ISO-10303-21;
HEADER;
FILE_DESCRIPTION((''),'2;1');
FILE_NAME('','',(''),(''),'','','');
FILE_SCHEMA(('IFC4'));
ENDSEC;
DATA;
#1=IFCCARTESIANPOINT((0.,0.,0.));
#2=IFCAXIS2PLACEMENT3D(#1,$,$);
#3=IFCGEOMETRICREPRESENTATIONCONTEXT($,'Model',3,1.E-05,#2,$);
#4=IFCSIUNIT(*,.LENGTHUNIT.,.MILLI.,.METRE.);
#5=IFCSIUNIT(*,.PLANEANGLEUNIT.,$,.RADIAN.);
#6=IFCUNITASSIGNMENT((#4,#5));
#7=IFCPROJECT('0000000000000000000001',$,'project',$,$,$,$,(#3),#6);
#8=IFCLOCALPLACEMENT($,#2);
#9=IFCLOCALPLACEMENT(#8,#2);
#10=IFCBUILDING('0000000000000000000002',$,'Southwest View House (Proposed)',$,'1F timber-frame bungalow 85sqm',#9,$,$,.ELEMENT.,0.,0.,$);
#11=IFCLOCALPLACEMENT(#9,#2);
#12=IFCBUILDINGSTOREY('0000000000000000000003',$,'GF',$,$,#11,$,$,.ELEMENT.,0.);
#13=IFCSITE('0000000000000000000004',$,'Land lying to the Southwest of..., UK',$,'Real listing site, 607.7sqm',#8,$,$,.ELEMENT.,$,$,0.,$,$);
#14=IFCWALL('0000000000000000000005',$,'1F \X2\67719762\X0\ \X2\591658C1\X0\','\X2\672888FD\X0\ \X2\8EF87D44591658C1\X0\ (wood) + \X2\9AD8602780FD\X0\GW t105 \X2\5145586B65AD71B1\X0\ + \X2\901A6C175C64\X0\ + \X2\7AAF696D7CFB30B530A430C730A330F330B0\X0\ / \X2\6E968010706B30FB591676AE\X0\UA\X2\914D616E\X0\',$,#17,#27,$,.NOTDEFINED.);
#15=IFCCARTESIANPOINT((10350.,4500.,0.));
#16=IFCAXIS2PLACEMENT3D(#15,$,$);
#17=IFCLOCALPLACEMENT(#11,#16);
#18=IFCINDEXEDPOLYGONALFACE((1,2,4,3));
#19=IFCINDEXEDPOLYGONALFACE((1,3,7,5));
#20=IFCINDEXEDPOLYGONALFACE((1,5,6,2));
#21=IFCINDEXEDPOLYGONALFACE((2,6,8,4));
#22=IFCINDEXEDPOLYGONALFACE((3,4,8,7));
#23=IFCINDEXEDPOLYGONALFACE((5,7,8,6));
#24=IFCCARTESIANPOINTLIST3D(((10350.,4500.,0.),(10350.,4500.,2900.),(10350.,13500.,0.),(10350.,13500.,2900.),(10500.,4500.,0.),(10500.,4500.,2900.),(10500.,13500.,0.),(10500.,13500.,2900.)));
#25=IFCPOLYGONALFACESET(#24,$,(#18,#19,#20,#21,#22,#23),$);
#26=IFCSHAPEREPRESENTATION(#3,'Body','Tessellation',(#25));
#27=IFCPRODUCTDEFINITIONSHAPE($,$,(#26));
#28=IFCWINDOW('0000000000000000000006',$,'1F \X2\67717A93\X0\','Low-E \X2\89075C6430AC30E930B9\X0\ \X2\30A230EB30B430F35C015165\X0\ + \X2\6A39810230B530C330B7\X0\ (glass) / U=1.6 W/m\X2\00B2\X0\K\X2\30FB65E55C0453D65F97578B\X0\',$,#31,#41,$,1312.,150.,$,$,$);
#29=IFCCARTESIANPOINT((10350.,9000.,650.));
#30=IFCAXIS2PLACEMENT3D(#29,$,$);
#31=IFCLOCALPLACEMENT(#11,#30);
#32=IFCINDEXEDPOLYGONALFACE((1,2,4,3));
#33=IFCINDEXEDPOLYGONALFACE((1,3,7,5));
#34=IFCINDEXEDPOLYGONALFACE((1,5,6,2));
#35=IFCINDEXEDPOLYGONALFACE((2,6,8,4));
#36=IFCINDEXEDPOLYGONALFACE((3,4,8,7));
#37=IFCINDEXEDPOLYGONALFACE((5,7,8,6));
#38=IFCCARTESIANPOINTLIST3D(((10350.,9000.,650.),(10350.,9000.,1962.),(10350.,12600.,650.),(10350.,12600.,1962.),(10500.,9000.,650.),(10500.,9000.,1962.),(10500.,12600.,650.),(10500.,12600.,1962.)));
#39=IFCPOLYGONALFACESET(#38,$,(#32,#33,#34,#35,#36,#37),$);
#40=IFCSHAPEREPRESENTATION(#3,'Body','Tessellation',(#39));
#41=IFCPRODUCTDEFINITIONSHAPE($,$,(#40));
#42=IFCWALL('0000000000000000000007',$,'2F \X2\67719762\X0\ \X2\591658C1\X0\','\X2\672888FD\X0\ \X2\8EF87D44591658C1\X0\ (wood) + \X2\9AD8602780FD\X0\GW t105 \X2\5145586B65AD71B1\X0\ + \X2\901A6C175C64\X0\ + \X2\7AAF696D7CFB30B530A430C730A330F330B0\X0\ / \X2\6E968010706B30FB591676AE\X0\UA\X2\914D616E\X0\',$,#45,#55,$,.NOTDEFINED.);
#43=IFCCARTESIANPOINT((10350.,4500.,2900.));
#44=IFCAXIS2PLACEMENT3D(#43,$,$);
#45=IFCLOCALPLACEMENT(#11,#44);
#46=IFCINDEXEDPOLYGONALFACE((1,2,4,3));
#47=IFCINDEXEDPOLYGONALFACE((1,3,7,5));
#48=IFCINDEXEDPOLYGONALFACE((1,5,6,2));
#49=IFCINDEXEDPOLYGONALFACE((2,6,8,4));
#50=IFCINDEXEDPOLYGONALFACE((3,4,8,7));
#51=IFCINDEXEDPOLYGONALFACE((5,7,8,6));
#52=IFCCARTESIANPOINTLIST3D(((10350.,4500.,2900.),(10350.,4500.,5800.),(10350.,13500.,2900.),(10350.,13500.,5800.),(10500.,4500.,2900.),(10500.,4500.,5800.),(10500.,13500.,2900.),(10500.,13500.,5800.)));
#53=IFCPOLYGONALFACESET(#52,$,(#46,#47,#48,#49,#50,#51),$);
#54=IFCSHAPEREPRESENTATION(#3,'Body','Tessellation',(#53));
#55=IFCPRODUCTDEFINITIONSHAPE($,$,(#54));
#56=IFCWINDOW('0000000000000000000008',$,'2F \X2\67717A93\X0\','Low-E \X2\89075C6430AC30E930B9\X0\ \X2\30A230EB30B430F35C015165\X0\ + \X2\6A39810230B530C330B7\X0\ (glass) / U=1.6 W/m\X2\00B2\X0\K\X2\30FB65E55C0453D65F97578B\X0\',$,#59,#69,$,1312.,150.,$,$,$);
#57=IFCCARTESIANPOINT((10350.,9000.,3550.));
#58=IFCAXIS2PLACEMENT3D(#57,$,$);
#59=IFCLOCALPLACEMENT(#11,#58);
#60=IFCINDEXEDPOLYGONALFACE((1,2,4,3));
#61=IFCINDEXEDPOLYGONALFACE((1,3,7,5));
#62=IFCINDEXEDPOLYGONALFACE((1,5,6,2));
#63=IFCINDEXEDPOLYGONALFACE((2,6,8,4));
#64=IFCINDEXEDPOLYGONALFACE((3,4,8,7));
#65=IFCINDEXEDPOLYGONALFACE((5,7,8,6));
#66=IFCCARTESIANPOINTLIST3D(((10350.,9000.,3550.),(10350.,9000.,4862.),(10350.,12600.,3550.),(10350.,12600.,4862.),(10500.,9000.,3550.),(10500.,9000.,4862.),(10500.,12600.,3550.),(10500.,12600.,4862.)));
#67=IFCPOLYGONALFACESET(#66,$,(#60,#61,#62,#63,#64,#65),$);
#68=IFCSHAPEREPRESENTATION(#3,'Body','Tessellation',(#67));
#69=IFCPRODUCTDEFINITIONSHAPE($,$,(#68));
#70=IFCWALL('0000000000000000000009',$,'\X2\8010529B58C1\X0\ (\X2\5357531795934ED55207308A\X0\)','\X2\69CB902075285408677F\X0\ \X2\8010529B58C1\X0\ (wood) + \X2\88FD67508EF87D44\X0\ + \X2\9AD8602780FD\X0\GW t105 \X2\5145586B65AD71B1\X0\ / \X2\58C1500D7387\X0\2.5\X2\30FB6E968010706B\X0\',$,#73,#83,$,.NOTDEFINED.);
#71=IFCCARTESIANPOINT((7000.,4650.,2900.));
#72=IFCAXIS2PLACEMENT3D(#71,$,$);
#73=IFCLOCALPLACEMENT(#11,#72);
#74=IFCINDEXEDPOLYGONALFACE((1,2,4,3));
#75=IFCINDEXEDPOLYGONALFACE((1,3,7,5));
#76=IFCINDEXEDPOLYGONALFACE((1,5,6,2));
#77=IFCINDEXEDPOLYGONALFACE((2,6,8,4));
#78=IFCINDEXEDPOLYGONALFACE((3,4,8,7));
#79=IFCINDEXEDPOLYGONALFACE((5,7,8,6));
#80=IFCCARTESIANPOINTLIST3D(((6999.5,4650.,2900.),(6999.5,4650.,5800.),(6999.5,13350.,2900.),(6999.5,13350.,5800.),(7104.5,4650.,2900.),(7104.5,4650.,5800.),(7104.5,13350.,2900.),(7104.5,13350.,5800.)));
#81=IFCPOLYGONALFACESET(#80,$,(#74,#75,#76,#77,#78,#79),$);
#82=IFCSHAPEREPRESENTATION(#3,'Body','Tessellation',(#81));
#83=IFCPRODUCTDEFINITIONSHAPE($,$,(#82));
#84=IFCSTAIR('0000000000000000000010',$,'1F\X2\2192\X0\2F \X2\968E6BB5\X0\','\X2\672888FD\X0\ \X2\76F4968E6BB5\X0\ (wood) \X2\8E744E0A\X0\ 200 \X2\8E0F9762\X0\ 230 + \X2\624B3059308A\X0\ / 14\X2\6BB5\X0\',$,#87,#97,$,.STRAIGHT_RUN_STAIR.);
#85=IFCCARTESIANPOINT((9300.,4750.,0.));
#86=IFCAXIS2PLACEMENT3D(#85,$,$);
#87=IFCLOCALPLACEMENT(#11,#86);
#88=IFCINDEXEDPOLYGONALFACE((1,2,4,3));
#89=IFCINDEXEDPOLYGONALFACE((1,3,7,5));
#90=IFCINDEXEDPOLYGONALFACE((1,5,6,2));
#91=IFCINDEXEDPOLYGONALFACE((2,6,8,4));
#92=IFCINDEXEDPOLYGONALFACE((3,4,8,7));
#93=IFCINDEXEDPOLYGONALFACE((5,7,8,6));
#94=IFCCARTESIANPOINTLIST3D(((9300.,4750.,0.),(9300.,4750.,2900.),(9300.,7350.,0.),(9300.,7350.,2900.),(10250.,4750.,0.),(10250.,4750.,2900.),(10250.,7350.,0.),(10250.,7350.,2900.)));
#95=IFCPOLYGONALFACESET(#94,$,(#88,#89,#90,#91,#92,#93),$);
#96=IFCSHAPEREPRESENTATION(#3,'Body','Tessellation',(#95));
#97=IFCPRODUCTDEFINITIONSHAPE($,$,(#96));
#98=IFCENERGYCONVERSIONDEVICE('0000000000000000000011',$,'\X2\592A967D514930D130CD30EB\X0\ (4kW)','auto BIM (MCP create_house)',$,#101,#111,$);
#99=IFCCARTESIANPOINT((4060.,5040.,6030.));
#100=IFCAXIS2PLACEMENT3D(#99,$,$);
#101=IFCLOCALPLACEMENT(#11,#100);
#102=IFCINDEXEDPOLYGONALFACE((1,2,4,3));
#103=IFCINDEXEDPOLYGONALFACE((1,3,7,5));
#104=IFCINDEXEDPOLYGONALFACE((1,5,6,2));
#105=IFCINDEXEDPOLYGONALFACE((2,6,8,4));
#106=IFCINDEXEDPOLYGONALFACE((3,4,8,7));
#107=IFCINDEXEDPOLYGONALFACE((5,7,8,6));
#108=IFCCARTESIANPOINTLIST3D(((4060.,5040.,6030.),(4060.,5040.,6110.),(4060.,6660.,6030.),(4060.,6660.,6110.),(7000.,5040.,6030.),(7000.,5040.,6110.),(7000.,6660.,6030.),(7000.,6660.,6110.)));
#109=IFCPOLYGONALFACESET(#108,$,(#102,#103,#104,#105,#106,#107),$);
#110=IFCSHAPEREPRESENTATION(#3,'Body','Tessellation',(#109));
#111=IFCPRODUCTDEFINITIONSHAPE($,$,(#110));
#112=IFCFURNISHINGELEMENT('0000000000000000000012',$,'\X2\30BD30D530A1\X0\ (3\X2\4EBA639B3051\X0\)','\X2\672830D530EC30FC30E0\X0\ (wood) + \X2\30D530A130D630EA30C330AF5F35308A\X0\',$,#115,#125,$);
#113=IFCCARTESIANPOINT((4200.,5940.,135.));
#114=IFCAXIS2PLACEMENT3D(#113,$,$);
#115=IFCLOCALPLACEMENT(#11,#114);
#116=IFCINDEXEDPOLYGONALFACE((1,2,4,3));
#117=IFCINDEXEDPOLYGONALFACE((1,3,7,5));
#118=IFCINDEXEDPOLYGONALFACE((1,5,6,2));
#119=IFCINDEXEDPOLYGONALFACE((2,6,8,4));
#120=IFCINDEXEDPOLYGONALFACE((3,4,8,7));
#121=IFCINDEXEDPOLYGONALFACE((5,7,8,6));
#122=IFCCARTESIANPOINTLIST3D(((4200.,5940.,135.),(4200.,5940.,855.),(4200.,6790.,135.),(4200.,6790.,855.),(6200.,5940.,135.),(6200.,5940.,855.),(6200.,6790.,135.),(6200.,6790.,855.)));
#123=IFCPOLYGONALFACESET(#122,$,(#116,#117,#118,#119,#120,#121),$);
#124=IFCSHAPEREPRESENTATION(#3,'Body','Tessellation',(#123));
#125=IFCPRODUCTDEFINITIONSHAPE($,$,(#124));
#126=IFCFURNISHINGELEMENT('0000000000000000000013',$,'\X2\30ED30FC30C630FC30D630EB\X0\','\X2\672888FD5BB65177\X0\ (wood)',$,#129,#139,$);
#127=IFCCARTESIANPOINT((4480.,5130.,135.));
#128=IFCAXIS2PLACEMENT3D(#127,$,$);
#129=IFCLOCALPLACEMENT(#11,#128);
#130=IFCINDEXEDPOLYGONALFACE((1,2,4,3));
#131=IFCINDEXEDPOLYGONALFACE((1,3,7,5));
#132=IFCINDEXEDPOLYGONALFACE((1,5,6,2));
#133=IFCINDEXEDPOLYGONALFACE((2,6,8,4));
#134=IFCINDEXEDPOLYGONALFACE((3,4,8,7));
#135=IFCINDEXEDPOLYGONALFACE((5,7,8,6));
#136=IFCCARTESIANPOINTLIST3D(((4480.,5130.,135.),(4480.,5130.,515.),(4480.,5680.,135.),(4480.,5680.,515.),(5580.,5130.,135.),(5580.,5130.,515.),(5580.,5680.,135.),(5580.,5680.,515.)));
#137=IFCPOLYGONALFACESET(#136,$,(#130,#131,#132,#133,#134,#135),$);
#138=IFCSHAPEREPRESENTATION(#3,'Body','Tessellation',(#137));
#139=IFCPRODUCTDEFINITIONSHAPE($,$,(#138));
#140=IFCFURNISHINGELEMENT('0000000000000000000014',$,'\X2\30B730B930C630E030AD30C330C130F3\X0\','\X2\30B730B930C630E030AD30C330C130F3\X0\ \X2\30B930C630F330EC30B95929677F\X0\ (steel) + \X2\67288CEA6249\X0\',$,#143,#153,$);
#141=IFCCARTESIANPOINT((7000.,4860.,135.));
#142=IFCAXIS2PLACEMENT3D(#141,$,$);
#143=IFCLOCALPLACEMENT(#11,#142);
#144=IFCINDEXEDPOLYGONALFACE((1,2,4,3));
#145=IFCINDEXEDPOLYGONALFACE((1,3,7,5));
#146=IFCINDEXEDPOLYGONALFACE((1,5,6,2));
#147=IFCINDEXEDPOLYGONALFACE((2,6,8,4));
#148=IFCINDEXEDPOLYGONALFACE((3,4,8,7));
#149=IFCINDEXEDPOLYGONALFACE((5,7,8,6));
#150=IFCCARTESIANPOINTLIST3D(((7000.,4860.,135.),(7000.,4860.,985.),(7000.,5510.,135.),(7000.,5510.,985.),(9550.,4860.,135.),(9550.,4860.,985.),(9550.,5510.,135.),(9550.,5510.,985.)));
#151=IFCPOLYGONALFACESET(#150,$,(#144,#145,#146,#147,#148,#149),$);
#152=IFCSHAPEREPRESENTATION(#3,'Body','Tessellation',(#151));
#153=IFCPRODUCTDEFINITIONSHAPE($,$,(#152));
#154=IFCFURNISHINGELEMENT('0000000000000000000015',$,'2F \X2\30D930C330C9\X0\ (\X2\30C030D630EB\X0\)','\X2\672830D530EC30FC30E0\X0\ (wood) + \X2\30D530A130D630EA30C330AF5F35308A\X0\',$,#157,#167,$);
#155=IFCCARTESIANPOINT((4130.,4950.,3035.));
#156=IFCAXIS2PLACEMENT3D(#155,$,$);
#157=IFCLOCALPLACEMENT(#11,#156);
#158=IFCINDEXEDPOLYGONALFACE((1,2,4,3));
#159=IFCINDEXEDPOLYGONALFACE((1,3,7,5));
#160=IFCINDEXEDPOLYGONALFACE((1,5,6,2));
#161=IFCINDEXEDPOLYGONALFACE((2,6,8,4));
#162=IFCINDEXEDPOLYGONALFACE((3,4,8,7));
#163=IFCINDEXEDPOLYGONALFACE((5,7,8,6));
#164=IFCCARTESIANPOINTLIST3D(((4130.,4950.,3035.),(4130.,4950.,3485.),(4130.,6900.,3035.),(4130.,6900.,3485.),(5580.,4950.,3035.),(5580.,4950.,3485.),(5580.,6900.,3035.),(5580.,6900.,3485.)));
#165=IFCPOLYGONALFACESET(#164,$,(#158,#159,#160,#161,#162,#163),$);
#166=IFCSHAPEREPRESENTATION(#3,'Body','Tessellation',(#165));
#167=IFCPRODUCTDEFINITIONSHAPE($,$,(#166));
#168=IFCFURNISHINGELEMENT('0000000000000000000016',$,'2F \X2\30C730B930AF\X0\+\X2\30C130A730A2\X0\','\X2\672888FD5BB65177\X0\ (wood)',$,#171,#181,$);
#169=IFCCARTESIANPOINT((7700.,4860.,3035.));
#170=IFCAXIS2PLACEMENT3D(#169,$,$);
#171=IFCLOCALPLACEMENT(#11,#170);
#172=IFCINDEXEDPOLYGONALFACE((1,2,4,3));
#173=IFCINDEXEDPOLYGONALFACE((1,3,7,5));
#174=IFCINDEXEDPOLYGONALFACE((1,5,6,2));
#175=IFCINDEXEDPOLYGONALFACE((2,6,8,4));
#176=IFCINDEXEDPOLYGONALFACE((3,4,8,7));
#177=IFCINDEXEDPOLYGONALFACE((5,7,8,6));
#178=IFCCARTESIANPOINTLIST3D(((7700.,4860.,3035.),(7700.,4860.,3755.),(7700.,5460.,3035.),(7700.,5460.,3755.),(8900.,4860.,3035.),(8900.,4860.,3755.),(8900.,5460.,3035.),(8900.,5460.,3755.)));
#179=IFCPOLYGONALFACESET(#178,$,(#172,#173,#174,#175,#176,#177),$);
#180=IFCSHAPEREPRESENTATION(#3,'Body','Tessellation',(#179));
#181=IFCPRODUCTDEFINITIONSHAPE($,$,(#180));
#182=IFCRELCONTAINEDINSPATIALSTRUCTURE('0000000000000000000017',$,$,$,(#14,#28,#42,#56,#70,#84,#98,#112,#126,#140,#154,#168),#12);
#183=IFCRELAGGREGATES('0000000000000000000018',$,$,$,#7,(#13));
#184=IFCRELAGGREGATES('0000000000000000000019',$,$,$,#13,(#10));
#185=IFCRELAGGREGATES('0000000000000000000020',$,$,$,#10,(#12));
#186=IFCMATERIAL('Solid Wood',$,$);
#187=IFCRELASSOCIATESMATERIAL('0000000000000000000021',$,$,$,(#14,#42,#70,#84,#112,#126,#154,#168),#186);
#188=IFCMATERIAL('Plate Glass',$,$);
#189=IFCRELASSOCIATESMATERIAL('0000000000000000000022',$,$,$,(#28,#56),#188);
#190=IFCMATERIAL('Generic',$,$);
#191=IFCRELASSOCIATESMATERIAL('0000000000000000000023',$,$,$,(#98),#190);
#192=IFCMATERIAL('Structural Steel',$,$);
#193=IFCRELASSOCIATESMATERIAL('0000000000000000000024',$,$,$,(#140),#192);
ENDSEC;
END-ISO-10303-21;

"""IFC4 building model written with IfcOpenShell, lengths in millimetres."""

from ifc_helpers import new_model, si_unit, frame, frame_2d, origin, place, context, project, spatial, rectangle, extrude, material, element, fill, save


model = new_model("IFC4")

# Units and contexts
model_context = context("Model", 3, precision=1e-05, world=origin())
ifc_project = project(units=[si_unit("LENGTHUNIT", "METRE", prefix="MILLI"), si_unit("PLANEANGLEUNIT", "RADIAN")], contexts=[model_context])

# Site, building, storey
site_placement = place(None, origin())
site = spatial("IfcSite", under=ifc_project, at=site_placement, Name="Land lying to the Southwest of..., UK", ObjectType="Real listing site, 607.7sqm", CompositionType="ELEMENT", RefElevation=0.0)
building_placement = place(site_placement, origin())
building = spatial("IfcBuilding", under=site, at=building_placement, Name="Southwest View House (Proposed)", ObjectType="1F timber-frame bungalow 85sqm", CompositionType="ELEMENT", ElevationOfRefHeight=0.0, ElevationOfTerrain=0.0)
storey_placement = place(building_placement, origin())
storey = spatial("IfcBuildingStorey", under=building, at=storey_placement, Name="GF", CompositionType="ELEMENT", Elevation=0.0)

# Wall, opening, window
ifc_material_1 = material(Name="Solid Wood")
wall_1_placement = place(storey_placement, frame((10350.0, 4500.0, 0.0)))
wall_1 = element("IfcWall", 1, at=wall_1_placement, inside=storey, material=ifc_material_1, Name="1F 東面 外壁", Description="木製 軸組外壁 (wood) + 高性能GW t105 充填断熱 + 通気層 + 窯業系サイディング / 準耐火・外皮UA配慮", PredefinedType="NOTDEFINED", context=model_context, shape_type="SweptSolid", body=[
    extrude(rectangle(XDim=150.0, YDim=9000.0, at=frame_2d((75.0, 4500.0))), frame((10350.0, 4500.0, 0.0)), (0.0, 0.0, 1.0), 2900.0),
])
opening_1_placement = place(storey_placement, frame((10350.0, 9000.0, 650.0)))
opening_1 = element("IfcOpeningElement", 2, at=opening_1_placement, cuts=wall_1, PredefinedType="NOTDEFINED", context=model_context, shape_type="SweptSolid", body=[
    extrude(rectangle(XDim=150.0, YDim=3600.0, at=frame_2d((75.0, 1800.0))), frame((10350.0, 9000.0, 650.0)), (0.0, 0.0, 1.0), 1312.0),
])
ifc_material_2 = material(Name="Plate Glass")
window_1_placement = place(storey_placement, frame((10350.0, 9000.0, 650.0)))
window_1 = element("IfcWindow", 3, at=window_1_placement, inside=storey, material=ifc_material_2, Name="1F 東窓", Description="Low-E 複層ガラス アルゴン封入 + 樹脂サッシ (glass) / U=1.6 W/m²K・日射取得型", OverallHeight=1312.0, OverallWidth=150.0, context=model_context, shape_type="SweptSolid", body=[
    extrude(rectangle(XDim=150.0, YDim=3600.0, at=frame_2d((75.0, 1800.0))), frame((10350.0, 9000.0, 650.0)), (0.0, 0.0, 1.0), 1312.0),
])
fill(opening_1, window_1)

# Wall, opening, window
wall_2_placement = place(storey_placement, frame((10350.0, 4500.0, 2900.0)))
wall_2 = element("IfcWall", 4, at=wall_2_placement, inside=storey, material=ifc_material_1, Name="2F 東面 外壁", Description="木製 軸組外壁 (wood) + 高性能GW t105 充填断熱 + 通気層 + 窯業系サイディング / 準耐火・外皮UA配慮", PredefinedType="NOTDEFINED", context=model_context, shape_type="SweptSolid", body=[
    extrude(rectangle(XDim=150.0, YDim=9000.0, at=frame_2d((75.0, 4500.0))), frame((10350.0, 4500.0, 2900.0)), (0.0, 0.0, 1.0), 2900.0),
])
opening_2_placement = place(storey_placement, frame((10350.0, 9000.0, 3550.0)))
opening_2 = element("IfcOpeningElement", 5, at=opening_2_placement, cuts=wall_2, PredefinedType="NOTDEFINED", context=model_context, shape_type="SweptSolid", body=[
    extrude(rectangle(XDim=150.0, YDim=3600.0, at=frame_2d((75.0, 1800.0))), frame((10350.0, 9000.0, 3550.0)), (0.0, 0.0, 1.0), 1312.0),
])
window_2_placement = place(storey_placement, frame((10350.0, 9000.0, 3550.0)))
window_2 = element("IfcWindow", 6, at=window_2_placement, inside=storey, material=ifc_material_2, Name="2F 東窓", Description="Low-E 複層ガラス アルゴン封入 + 樹脂サッシ (glass) / U=1.6 W/m²K・日射取得型", OverallHeight=1312.0, OverallWidth=150.0, context=model_context, shape_type="SweptSolid", body=[
    extrude(rectangle(XDim=150.0, YDim=3600.0, at=frame_2d((75.0, 1800.0))), frame((10350.0, 9000.0, 3550.0)), (0.0, 0.0, 1.0), 1312.0),
])
fill(opening_2, window_2)

# Wall
wall_3_placement = place(storey_placement, frame((7000.0, 4650.0, 2900.0)))
element("IfcWall", 7, at=wall_3_placement, inside=storey, material=ifc_material_1, Name="耐力壁 (南北間仕切り)", Description="構造用合板 耐力壁 (wood) + 製材軸組 + 高性能GW t105 充填断熱 / 壁倍率2.5・準耐火", PredefinedType="NOTDEFINED", context=model_context, shape_type="SweptSolid", body=[
    extrude(rectangle(XDim=105.0, YDim=8700.0, at=frame_2d((52.0, 4350.0))), frame((7000.0, 4650.0, 2900.0)), (0.0, 0.0, 1.0), 2900.0),
])

# Stair
stair_placement = place(storey_placement, frame((9300.0, 4750.0, 0.0)))
element("IfcStair", 8, at=stair_placement, inside=storey, material=ifc_material_1, Name="1F→2F 階段", Description="木製 直階段 (wood) 蹴上 200 踏面 230 + 手すり / 14段", PredefinedType="STRAIGHT_RUN_STAIR", context=model_context, shape_type="SweptSolid", body=[
    extrude(rectangle(XDim=950.0, YDim=2600.0, at=frame_2d((475.0, 1300.0))), frame((9300.0, 4750.0, 0.0)), (0.0, 0.0, 1.0), 2900.0),
])

# Energy conversion device
ifc_material_3 = material(Name="Generic")
energy_conversion_device_placement = place(storey_placement, frame((4060.0, 5040.0, 6030.0)))
element("IfcEnergyConversionDevice", 9, at=energy_conversion_device_placement, inside=storey, material=ifc_material_3, Name="太陽光パネル (4kW)", Description="auto BIM (MCP create_house)", context=model_context, shape_type="SweptSolid", body=[
    extrude(rectangle(XDim=2940.0, YDim=1620.0, at=frame_2d((1470.0, 810.0))), frame((4060.0, 5040.0, 6030.0)), (0.0, 0.0, 1.0), 80.0),
])

# Furnishing elements
furnishing_1_placement = place(storey_placement, frame((4200.0, 5940.0, 135.0)))
element("IfcFurnishingElement", 10, at=furnishing_1_placement, inside=storey, material=ifc_material_1, Name="ソファ (3人掛け)", Description="木フレーム (wood) + ファブリック張り", context=model_context, shape_type="SweptSolid", body=[
    extrude(rectangle(XDim=2000.0, YDim=850.0, at=frame_2d((1000.0, 425.0))), frame((4200.0, 5940.0, 135.0)), (0.0, 0.0, 1.0), 720.0),
])
furnishing_2_placement = place(storey_placement, frame((4480.0, 5130.0, 135.0)))
element("IfcFurnishingElement", 11, at=furnishing_2_placement, inside=storey, material=ifc_material_1, Name="ローテーブル", Description="木製家具 (wood)", context=model_context, shape_type="SweptSolid", body=[
    extrude(rectangle(XDim=1100.0, YDim=550.0, at=frame_2d((550.0, 275.0))), frame((4480.0, 5130.0, 135.0)), (0.0, 0.0, 1.0), 380.0),
])
ifc_material_4 = material(Name="Structural Steel")
furnishing_3_placement = place(storey_placement, frame((7000.0, 4860.0, 135.0)))
element("IfcFurnishingElement", 12, at=furnishing_3_placement, inside=storey, material=ifc_material_4, Name="システムキッチン", Description="システムキッチン ステンレス天板 (steel) + 木質扉", context=model_context, shape_type="SweptSolid", body=[
    extrude(rectangle(XDim=2550.0, YDim=650.0, at=frame_2d((1275.0, 325.0))), frame((7000.0, 4860.0, 135.0)), (0.0, 0.0, 1.0), 850.0),
])
furnishing_4_placement = place(storey_placement, frame((4130.0, 4950.0, 3035.0)))
element("IfcFurnishingElement", 13, at=furnishing_4_placement, inside=storey, material=ifc_material_1, Name="2F ベッド (ダブル)", Description="木フレーム (wood) + ファブリック張り", context=model_context, shape_type="SweptSolid", body=[
    extrude(rectangle(XDim=1450.0, YDim=1950.0, at=frame_2d((725.0, 975.0))), frame((4130.0, 4950.0, 3035.0)), (0.0, 0.0, 1.0), 450.0),
])
furnishing_5_placement = place(storey_placement, frame((7700.0, 4860.0, 3035.0)))
element("IfcFurnishingElement", 14, at=furnishing_5_placement, inside=storey, material=ifc_material_1, Name="2F デスク+チェア", Description="木製家具 (wood)", context=model_context, shape_type="SweptSolid", body=[
    extrude(rectangle(XDim=1200.0, YDim=600.0, at=frame_2d((600.0, 300.0))), frame((7700.0, 4860.0, 3035.0)), (0.0, 0.0, 1.0), 720.0),
])

save(model, "model.ifc")
